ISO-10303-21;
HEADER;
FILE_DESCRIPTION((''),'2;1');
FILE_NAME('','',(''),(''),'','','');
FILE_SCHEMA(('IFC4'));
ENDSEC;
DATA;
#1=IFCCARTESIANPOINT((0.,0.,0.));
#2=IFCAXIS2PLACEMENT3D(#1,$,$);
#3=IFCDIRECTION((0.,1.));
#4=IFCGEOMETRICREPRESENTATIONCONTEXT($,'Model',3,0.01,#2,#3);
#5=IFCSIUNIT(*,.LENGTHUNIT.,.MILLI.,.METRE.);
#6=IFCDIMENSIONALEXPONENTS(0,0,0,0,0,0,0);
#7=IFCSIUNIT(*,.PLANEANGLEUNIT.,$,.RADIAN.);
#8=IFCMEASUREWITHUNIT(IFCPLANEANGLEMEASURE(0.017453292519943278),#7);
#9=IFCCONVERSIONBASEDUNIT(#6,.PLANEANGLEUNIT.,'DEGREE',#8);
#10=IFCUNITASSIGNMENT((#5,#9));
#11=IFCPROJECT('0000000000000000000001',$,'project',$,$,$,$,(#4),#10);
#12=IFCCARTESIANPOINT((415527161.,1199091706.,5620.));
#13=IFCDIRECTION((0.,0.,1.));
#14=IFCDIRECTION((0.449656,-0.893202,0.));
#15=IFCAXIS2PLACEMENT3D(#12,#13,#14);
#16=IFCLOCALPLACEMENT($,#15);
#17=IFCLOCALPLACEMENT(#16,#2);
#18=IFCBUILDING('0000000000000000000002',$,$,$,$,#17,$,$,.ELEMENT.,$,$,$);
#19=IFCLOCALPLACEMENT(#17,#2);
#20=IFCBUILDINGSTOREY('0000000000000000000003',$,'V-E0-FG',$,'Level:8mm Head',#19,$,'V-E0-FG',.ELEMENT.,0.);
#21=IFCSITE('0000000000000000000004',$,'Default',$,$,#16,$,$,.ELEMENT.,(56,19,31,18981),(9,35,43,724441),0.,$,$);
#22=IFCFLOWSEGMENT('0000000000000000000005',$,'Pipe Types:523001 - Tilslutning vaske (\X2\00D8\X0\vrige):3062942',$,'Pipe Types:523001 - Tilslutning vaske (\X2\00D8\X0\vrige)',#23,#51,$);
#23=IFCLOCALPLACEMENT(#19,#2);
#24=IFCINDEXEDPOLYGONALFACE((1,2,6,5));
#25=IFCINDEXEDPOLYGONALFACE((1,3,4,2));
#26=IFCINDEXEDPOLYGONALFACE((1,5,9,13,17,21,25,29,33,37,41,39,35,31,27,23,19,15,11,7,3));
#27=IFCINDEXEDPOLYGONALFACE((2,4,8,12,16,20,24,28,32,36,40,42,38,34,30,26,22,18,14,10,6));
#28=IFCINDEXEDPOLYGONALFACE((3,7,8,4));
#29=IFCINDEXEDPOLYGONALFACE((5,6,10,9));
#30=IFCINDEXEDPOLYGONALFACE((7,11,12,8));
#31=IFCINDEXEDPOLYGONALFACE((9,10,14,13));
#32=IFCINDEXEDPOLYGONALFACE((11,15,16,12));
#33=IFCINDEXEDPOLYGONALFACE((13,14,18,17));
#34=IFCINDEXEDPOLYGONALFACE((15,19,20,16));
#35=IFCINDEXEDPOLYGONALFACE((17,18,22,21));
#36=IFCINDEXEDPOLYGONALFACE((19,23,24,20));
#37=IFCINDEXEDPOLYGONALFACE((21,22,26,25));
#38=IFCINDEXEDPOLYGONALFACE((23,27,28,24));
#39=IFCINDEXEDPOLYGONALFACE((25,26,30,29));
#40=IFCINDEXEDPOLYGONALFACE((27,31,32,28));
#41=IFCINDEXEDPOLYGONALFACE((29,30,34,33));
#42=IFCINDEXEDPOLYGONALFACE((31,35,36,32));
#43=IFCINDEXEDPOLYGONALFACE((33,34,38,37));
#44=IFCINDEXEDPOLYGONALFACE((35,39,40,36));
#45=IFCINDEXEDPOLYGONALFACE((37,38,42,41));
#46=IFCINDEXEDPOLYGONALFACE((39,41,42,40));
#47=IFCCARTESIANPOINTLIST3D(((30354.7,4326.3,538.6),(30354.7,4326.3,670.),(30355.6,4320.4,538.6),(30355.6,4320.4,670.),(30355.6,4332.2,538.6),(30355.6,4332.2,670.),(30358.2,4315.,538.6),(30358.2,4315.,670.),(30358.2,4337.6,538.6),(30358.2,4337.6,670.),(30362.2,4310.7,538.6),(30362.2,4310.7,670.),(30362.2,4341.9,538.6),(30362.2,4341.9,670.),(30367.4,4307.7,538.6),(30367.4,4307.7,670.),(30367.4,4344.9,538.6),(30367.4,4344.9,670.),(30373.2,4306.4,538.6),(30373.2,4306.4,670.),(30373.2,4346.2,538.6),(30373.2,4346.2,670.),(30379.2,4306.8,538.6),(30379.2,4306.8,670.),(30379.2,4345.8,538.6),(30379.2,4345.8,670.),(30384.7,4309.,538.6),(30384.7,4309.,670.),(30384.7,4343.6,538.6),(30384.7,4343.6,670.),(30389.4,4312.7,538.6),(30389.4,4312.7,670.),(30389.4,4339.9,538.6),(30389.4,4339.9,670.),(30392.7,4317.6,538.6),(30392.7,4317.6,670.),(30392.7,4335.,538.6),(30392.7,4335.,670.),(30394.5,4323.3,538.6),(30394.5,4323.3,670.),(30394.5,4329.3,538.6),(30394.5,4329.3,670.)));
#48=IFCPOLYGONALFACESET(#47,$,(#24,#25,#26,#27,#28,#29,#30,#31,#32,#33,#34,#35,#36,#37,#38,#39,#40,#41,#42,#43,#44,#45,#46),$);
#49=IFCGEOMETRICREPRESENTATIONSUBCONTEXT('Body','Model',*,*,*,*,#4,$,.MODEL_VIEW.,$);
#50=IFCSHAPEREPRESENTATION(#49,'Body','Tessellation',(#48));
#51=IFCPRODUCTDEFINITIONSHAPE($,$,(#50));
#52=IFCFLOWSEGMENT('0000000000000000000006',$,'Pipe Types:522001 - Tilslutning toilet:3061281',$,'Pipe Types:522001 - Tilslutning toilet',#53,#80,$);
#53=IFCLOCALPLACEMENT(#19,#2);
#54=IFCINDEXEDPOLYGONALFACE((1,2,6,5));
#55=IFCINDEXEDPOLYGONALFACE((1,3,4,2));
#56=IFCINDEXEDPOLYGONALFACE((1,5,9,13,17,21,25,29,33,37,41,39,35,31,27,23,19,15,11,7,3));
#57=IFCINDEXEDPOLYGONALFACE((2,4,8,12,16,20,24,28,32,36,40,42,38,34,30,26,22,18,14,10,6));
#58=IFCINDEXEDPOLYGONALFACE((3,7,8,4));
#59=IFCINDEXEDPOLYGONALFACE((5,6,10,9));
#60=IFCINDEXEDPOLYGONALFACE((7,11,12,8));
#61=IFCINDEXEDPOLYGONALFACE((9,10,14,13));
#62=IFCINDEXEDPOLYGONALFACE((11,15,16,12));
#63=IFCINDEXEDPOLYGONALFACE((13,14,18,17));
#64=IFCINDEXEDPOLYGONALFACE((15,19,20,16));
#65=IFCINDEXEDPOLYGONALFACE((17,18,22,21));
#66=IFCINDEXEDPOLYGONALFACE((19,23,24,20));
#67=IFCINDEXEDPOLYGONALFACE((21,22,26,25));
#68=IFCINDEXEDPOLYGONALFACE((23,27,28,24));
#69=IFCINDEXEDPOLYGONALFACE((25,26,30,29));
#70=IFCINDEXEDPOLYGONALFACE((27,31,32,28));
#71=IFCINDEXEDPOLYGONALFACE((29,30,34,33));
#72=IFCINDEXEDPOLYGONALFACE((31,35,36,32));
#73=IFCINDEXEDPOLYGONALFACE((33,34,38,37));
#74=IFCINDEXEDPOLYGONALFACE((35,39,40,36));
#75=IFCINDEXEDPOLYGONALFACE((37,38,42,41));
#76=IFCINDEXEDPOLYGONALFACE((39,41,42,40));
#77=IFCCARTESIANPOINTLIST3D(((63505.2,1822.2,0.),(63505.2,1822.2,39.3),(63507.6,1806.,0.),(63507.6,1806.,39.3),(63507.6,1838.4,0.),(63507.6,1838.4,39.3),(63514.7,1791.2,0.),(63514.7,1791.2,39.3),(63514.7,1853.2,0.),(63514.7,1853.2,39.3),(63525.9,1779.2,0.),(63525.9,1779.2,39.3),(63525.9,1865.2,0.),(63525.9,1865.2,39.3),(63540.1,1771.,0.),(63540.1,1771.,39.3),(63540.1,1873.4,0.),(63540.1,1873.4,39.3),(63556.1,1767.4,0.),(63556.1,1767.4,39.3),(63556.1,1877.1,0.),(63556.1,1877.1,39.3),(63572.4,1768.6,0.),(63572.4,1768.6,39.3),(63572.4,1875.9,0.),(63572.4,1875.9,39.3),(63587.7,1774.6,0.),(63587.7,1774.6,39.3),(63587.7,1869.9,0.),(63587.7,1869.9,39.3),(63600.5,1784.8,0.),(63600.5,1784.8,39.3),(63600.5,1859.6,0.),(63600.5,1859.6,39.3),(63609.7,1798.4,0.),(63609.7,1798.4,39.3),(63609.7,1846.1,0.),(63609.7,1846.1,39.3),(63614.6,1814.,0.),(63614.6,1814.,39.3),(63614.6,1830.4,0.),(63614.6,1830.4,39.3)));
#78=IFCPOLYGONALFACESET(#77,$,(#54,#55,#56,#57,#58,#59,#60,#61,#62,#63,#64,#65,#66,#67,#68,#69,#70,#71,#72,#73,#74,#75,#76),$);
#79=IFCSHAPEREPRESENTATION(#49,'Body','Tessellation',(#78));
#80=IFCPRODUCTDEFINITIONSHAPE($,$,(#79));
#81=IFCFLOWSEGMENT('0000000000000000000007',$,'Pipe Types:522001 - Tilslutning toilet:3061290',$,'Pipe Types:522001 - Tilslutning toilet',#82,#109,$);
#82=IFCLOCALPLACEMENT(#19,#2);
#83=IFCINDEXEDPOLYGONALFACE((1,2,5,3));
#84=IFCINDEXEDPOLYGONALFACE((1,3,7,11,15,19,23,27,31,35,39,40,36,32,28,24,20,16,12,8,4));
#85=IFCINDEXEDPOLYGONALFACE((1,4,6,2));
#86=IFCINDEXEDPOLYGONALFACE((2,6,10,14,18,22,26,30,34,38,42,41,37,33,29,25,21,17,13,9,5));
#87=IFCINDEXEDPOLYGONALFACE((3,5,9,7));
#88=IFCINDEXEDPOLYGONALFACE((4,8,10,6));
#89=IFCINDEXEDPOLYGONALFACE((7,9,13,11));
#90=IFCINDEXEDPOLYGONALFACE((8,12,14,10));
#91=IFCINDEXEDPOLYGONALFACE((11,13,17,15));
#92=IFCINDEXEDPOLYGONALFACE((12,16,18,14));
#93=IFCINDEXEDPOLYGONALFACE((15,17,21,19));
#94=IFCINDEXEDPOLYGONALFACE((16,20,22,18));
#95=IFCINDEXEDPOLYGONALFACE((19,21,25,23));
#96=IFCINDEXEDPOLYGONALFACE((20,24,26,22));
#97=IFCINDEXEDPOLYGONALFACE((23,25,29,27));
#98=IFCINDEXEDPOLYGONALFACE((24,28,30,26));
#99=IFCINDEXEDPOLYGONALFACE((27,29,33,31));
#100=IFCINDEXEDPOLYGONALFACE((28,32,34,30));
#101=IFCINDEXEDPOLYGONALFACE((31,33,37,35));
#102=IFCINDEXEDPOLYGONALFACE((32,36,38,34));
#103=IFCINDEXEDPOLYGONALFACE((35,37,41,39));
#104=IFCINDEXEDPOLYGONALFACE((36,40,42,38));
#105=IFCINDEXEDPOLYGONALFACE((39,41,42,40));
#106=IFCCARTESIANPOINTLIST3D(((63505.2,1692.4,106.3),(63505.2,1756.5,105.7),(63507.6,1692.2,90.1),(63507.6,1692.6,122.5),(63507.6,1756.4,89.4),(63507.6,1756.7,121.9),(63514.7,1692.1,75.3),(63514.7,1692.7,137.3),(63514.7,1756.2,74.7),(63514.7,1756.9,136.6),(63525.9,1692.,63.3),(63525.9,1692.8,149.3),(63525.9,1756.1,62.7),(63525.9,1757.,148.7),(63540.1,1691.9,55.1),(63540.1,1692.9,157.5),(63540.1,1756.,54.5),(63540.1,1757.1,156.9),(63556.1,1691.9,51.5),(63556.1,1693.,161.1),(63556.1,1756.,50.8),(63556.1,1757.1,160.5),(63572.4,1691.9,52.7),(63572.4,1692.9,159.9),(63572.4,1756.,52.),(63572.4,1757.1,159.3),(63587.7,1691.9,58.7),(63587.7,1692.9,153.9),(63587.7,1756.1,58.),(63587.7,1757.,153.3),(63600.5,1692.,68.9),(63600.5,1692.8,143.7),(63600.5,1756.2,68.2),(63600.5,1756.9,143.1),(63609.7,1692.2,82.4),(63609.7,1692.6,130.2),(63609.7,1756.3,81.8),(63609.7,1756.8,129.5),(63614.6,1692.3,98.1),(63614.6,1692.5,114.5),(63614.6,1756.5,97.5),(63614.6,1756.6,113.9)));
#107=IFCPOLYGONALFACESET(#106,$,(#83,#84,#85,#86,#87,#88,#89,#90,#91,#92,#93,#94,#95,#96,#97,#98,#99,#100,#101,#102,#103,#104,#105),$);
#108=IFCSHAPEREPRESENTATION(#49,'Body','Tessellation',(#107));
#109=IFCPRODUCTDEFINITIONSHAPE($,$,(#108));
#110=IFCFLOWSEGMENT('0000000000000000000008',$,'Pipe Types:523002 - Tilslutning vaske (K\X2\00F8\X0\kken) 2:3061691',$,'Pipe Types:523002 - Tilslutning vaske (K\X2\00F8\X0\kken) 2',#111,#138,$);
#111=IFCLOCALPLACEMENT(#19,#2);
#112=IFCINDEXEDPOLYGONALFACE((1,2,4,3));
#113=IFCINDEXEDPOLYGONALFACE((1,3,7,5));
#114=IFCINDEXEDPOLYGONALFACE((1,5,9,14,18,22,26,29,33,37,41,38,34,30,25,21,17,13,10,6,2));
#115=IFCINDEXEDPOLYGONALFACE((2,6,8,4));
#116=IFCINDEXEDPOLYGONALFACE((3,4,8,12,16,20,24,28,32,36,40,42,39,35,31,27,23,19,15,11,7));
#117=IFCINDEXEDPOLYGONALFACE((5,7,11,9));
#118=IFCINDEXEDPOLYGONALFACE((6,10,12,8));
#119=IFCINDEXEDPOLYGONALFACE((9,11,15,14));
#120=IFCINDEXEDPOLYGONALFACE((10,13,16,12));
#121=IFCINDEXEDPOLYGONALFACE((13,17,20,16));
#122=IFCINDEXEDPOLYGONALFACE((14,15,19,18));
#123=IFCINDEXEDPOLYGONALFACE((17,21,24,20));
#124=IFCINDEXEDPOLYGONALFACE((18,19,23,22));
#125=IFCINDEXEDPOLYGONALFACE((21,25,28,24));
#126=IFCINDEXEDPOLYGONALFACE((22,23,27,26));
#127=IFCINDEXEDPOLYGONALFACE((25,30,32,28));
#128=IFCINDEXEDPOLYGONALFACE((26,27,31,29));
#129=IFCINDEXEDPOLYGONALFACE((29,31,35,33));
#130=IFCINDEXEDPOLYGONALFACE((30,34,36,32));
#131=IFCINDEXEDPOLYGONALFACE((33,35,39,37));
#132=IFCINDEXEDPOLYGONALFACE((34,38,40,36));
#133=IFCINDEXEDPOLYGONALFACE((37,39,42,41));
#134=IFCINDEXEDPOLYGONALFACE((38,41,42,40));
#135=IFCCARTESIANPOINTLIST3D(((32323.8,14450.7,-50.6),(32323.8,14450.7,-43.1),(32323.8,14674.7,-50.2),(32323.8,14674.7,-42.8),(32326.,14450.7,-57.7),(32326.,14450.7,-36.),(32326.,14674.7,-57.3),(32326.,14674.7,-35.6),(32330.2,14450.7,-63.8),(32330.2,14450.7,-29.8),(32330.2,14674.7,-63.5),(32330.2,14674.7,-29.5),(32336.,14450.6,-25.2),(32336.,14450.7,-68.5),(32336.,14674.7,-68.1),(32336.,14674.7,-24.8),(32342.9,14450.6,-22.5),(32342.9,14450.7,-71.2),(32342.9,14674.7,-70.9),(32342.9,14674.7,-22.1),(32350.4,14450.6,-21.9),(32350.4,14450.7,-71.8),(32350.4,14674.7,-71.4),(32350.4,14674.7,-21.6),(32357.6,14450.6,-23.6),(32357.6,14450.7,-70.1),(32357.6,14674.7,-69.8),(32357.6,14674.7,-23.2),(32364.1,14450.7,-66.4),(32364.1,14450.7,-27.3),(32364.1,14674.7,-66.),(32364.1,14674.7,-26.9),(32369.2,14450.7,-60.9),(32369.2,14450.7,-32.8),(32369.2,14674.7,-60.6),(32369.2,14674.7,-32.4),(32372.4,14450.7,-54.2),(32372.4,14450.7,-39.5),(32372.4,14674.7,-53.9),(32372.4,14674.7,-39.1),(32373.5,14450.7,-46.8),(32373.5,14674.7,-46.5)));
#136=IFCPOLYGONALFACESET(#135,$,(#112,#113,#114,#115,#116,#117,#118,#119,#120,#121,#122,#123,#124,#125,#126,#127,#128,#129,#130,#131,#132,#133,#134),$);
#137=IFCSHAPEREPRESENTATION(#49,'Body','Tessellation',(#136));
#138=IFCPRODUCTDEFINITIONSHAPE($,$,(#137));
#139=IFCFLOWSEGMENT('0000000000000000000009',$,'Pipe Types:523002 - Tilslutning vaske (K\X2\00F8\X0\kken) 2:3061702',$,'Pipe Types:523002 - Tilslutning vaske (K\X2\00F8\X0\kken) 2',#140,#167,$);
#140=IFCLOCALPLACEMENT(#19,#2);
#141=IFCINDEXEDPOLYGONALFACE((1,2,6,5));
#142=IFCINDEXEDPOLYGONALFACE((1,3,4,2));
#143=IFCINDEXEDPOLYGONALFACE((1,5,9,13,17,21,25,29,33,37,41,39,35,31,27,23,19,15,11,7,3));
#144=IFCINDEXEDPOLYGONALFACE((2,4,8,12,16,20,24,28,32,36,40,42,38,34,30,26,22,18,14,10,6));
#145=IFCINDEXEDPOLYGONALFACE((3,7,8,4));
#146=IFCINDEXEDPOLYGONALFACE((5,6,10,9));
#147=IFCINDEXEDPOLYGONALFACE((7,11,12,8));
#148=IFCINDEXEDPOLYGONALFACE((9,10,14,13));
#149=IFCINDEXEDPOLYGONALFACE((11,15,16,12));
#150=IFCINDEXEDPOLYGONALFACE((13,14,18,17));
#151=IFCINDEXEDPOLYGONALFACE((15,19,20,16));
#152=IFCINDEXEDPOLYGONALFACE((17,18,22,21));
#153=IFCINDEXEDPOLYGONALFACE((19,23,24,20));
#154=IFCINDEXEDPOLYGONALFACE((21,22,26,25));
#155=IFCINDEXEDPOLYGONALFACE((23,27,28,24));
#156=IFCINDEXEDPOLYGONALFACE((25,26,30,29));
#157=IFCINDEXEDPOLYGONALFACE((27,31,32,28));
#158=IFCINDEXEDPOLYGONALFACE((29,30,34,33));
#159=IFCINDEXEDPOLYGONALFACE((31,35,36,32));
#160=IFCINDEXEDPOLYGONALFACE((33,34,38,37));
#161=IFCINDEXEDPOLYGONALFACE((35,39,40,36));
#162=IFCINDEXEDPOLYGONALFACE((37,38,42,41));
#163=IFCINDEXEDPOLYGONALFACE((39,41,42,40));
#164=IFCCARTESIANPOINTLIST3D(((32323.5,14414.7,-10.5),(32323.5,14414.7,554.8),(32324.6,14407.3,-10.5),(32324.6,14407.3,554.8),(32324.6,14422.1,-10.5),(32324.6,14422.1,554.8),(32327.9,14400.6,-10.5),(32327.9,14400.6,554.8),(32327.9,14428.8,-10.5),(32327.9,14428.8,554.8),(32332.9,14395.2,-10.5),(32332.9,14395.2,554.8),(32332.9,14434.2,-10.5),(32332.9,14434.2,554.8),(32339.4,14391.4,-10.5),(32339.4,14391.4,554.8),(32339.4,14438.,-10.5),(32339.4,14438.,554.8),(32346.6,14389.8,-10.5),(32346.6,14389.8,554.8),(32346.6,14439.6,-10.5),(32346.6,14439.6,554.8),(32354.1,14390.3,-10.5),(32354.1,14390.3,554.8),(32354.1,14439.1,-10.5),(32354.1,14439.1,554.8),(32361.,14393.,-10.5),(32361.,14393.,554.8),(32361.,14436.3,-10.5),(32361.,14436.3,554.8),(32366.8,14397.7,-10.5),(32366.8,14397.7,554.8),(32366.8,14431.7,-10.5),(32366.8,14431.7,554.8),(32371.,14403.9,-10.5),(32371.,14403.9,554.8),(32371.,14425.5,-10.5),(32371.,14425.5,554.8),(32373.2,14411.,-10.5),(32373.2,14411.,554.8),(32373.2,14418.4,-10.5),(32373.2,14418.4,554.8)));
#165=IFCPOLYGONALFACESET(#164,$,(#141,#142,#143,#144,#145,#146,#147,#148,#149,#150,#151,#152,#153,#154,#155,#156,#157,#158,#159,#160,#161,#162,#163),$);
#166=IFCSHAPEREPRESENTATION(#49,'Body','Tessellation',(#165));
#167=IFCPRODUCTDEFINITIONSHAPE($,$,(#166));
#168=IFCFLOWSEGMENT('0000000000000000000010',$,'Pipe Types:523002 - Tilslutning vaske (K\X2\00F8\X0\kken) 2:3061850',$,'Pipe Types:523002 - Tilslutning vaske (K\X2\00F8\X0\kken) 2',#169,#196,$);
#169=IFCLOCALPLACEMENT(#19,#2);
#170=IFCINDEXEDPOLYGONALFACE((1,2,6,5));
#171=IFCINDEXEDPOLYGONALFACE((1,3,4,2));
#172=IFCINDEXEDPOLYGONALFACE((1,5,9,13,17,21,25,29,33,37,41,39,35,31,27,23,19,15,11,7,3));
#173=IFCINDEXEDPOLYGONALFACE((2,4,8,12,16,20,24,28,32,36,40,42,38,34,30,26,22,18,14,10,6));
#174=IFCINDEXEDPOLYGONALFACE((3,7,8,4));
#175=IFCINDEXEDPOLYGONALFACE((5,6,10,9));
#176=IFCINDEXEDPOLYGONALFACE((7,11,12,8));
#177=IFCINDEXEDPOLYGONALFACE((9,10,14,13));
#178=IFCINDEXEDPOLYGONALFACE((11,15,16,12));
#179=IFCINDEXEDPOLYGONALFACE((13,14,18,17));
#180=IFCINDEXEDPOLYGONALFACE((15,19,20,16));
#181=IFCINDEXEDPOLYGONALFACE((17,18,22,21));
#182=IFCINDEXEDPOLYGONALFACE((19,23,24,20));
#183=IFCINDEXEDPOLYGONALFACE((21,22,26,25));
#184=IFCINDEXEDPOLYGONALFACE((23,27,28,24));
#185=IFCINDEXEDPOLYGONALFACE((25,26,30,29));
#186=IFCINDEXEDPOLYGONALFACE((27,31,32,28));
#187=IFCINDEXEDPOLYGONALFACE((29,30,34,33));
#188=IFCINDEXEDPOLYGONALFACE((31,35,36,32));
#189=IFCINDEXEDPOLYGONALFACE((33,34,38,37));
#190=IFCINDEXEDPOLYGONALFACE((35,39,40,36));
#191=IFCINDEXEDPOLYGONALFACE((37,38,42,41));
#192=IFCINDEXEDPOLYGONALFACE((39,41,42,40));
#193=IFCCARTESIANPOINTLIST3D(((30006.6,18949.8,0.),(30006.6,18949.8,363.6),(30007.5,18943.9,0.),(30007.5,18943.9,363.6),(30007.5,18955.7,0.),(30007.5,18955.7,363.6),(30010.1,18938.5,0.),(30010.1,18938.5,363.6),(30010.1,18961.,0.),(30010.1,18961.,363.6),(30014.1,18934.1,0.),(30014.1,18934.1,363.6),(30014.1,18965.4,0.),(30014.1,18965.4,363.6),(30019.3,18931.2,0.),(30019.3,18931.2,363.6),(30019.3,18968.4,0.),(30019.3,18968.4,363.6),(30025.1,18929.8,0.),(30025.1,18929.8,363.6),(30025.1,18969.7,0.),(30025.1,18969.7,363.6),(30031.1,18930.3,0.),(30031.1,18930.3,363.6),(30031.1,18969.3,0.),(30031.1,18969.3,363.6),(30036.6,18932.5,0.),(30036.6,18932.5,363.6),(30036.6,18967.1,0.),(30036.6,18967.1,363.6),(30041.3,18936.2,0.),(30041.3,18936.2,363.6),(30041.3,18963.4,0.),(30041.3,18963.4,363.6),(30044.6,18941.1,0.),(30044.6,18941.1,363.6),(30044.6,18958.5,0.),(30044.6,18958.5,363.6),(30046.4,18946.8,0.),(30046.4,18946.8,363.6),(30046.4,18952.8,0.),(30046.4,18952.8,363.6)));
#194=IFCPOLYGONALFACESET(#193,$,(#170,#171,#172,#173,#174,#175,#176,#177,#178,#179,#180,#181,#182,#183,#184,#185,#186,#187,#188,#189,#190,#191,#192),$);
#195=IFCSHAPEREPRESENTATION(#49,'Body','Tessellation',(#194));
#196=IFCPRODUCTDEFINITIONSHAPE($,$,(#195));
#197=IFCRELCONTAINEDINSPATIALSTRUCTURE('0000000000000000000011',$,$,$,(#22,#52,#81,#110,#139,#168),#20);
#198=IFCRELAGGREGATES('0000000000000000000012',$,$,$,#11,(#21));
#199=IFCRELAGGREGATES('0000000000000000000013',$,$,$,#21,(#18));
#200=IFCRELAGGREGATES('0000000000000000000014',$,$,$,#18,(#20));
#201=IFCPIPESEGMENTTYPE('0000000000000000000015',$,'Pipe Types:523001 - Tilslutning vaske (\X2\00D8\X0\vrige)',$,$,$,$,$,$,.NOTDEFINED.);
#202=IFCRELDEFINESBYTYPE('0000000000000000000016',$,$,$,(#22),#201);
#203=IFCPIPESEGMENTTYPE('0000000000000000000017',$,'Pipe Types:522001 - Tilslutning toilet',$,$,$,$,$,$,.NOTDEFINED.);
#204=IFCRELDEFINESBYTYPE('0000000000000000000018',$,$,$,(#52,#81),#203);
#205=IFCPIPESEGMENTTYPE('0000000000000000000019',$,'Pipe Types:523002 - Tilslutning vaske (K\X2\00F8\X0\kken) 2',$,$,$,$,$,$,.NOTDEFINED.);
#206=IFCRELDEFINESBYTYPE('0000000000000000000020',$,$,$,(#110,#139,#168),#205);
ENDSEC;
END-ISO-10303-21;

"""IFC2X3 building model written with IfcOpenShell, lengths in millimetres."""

from ifc_helpers import new_model, entity, si_unit, converted_unit, direction, frame, frame_2d, origin, origin_2d_with_axis, place, context, subcontext, project, spatial, circle, extrude, type_object, element, save


model = new_model("IFC2X3")

# Units and contexts
model_context = context("Model", 3, precision=0.01, world=origin(), true_north=direction((0.0, 1.0)))
body_context = subcontext(model_context, "Body", "Model", "MODEL_VIEW")
ifc_project = project(units=[si_unit("LENGTHUNIT", "METRE", prefix="MILLI"), converted_unit("PLANEANGLEUNIT", "DEGREE", entity("IfcPlaneAngleMeasure", 0.017453292519943278), si_unit("PLANEANGLEUNIT", "RADIAN"), dimensions=[0, 0, 0, 0, 0, 0, 0])], contexts=[model_context])

# Site, building, storey
site_placement = place(None, frame((415527161.0, 1199091706.0, 5620.0), z_axis=(0.0, 0.0, 1.0), x_axis=(0.449656, -0.893202, 0.0)))
site = spatial("IfcSite", under=ifc_project, at=site_placement, Name="Default", CompositionType="ELEMENT", RefLatitude=(56, 19, 31, 18981), RefLongitude=(9, 35, 43, 724441), RefElevation=0.0)
building_placement = place(site_placement, origin())
building = spatial("IfcBuilding", under=site, at=building_placement, CompositionType="ELEMENT")
storey_placement = place(building_placement, origin())
storey = spatial("IfcBuildingStorey", under=building, at=storey_placement, Name="V-E0-FG", ObjectType="Level:8mm Head", LongName="V-E0-FG", CompositionType="ELEMENT", Elevation=0.0)

# Flow segments
pipe_segment_type_1 = type_object("IfcPipeSegmentType", Name="Pipe Types:523001 - Tilslutning vaske (Øvrige)", PredefinedType="NOTDEFINED")
flow_segment_1_placement = place(storey_placement, origin())
element("IfcFlowSegment", 1, at=flow_segment_1_placement, inside=storey, type_object=pipe_segment_type_1, Name="Pipe Types:523001 - Tilslutning vaske (Øvrige):3062942", ObjectType="Pipe Types:523001 - Tilslutning vaske (Øvrige)", context=body_context, shape_type="SweptSolid", body=[
    extrude(circle(Radius=20.0, at=origin_2d_with_axis()), frame((30374.7, 4326.3, 538.6), z_axis=(0.0, 0.0, 1.0), x_axis=(-1.0, 0.0, 0.0)), (0.0, 0.0, 1.0), 131.4),
])
pipe_segment_type_2 = type_object("IfcPipeSegmentType", Name="Pipe Types:522001 - Tilslutning toilet", PredefinedType="NOTDEFINED")
flow_segment_2_placement = place(storey_placement, origin())
element("IfcFlowSegment", 2, at=flow_segment_2_placement, inside=storey, type_object=pipe_segment_type_2, Name="Pipe Types:522001 - Tilslutning toilet:3061281", ObjectType="Pipe Types:522001 - Tilslutning toilet", context=body_context, shape_type="SweptSolid", body=[
    extrude(circle(Radius=55.0, at=frame_2d((0.0, 0.0), x_axis=(1.0, 0.0))), frame((63560.2, 1822.2, 0.0), z_axis=(0.0, 0.0, 1.0), x_axis=(-1.0, 0.0, 0.0)), (0.0, 0.0, 1.0), 39.3),
])
flow_segment_3_placement = place(storey_placement, origin())
element("IfcFlowSegment", 3, at=flow_segment_3_placement, inside=storey, type_object=pipe_segment_type_2, Name="Pipe Types:522001 - Tilslutning toilet:3061290", ObjectType="Pipe Types:522001 - Tilslutning toilet", context=body_context, shape_type="SweptSolid", body=[
    extrude(circle(Radius=55.0, at=frame_2d((0.0, 0.0), x_axis=(1.0, 0.0))), frame((63560.2, 1692.4, 106.3), z_axis=(0.0, 0.99995, -0.01), x_axis=(-1.0, 0.0, 0.0)), (0.0, 0.0, 1.0), 64.1),
])
pipe_segment_type_3 = type_object("IfcPipeSegmentType", Name="Pipe Types:523002 - Tilslutning vaske (Køkken) 2", PredefinedType="NOTDEFINED")
flow_segment_4_placement = place(storey_placement, origin())
element("IfcFlowSegment", 4, at=flow_segment_4_placement, inside=storey, type_object=pipe_segment_type_3, Name="Pipe Types:523002 - Tilslutning vaske (Køkken) 2:3061691", ObjectType="Pipe Types:523002 - Tilslutning vaske (Køkken) 2", context=body_context, shape_type="SweptSolid", body=[
    extrude(circle(Radius=25.0, at=frame_2d((0.0, 0.0), x_axis=(1.0, 0.0))), frame((32348.5, 14450.7, -46.8), z_axis=(0.0, 0.999999, 0.001606), x_axis=(1.0, 0.0, 0.0)), (0.0, 0.0, 1.0), 224.0),
])
flow_segment_5_placement = place(storey_placement, origin())
element("IfcFlowSegment", 5, at=flow_segment_5_placement, inside=storey, type_object=pipe_segment_type_3, Name="Pipe Types:523002 - Tilslutning vaske (Køkken) 2:3061702", ObjectType="Pipe Types:523002 - Tilslutning vaske (Køkken) 2", context=body_context, shape_type="SweptSolid", body=[
    extrude(circle(Radius=25.0, at=origin_2d_with_axis()), frame((32348.5, 14414.7, -10.5), z_axis=(0.0, 0.0, 1.0), x_axis=(-1.0, 0.0, 0.0)), (0.0, 0.0, 1.0), 565.3),
])
flow_segment_6_placement = place(storey_placement, origin())
element("IfcFlowSegment", 6, at=flow_segment_6_placement, inside=storey, type_object=pipe_segment_type_3, Name="Pipe Types:523002 - Tilslutning vaske (Køkken) 2:3061850", ObjectType="Pipe Types:523002 - Tilslutning vaske (Køkken) 2", context=body_context, shape_type="SweptSolid", body=[
    extrude(circle(Radius=20.0, at=origin_2d_with_axis()), frame((30026.6, 18949.8, 0.0), z_axis=(0.0, 0.0, 1.0), x_axis=(-1.0, 0.0, 0.0)), (0.0, 0.0, 1.0), 363.6),
])

save(model, "model.ifc")
